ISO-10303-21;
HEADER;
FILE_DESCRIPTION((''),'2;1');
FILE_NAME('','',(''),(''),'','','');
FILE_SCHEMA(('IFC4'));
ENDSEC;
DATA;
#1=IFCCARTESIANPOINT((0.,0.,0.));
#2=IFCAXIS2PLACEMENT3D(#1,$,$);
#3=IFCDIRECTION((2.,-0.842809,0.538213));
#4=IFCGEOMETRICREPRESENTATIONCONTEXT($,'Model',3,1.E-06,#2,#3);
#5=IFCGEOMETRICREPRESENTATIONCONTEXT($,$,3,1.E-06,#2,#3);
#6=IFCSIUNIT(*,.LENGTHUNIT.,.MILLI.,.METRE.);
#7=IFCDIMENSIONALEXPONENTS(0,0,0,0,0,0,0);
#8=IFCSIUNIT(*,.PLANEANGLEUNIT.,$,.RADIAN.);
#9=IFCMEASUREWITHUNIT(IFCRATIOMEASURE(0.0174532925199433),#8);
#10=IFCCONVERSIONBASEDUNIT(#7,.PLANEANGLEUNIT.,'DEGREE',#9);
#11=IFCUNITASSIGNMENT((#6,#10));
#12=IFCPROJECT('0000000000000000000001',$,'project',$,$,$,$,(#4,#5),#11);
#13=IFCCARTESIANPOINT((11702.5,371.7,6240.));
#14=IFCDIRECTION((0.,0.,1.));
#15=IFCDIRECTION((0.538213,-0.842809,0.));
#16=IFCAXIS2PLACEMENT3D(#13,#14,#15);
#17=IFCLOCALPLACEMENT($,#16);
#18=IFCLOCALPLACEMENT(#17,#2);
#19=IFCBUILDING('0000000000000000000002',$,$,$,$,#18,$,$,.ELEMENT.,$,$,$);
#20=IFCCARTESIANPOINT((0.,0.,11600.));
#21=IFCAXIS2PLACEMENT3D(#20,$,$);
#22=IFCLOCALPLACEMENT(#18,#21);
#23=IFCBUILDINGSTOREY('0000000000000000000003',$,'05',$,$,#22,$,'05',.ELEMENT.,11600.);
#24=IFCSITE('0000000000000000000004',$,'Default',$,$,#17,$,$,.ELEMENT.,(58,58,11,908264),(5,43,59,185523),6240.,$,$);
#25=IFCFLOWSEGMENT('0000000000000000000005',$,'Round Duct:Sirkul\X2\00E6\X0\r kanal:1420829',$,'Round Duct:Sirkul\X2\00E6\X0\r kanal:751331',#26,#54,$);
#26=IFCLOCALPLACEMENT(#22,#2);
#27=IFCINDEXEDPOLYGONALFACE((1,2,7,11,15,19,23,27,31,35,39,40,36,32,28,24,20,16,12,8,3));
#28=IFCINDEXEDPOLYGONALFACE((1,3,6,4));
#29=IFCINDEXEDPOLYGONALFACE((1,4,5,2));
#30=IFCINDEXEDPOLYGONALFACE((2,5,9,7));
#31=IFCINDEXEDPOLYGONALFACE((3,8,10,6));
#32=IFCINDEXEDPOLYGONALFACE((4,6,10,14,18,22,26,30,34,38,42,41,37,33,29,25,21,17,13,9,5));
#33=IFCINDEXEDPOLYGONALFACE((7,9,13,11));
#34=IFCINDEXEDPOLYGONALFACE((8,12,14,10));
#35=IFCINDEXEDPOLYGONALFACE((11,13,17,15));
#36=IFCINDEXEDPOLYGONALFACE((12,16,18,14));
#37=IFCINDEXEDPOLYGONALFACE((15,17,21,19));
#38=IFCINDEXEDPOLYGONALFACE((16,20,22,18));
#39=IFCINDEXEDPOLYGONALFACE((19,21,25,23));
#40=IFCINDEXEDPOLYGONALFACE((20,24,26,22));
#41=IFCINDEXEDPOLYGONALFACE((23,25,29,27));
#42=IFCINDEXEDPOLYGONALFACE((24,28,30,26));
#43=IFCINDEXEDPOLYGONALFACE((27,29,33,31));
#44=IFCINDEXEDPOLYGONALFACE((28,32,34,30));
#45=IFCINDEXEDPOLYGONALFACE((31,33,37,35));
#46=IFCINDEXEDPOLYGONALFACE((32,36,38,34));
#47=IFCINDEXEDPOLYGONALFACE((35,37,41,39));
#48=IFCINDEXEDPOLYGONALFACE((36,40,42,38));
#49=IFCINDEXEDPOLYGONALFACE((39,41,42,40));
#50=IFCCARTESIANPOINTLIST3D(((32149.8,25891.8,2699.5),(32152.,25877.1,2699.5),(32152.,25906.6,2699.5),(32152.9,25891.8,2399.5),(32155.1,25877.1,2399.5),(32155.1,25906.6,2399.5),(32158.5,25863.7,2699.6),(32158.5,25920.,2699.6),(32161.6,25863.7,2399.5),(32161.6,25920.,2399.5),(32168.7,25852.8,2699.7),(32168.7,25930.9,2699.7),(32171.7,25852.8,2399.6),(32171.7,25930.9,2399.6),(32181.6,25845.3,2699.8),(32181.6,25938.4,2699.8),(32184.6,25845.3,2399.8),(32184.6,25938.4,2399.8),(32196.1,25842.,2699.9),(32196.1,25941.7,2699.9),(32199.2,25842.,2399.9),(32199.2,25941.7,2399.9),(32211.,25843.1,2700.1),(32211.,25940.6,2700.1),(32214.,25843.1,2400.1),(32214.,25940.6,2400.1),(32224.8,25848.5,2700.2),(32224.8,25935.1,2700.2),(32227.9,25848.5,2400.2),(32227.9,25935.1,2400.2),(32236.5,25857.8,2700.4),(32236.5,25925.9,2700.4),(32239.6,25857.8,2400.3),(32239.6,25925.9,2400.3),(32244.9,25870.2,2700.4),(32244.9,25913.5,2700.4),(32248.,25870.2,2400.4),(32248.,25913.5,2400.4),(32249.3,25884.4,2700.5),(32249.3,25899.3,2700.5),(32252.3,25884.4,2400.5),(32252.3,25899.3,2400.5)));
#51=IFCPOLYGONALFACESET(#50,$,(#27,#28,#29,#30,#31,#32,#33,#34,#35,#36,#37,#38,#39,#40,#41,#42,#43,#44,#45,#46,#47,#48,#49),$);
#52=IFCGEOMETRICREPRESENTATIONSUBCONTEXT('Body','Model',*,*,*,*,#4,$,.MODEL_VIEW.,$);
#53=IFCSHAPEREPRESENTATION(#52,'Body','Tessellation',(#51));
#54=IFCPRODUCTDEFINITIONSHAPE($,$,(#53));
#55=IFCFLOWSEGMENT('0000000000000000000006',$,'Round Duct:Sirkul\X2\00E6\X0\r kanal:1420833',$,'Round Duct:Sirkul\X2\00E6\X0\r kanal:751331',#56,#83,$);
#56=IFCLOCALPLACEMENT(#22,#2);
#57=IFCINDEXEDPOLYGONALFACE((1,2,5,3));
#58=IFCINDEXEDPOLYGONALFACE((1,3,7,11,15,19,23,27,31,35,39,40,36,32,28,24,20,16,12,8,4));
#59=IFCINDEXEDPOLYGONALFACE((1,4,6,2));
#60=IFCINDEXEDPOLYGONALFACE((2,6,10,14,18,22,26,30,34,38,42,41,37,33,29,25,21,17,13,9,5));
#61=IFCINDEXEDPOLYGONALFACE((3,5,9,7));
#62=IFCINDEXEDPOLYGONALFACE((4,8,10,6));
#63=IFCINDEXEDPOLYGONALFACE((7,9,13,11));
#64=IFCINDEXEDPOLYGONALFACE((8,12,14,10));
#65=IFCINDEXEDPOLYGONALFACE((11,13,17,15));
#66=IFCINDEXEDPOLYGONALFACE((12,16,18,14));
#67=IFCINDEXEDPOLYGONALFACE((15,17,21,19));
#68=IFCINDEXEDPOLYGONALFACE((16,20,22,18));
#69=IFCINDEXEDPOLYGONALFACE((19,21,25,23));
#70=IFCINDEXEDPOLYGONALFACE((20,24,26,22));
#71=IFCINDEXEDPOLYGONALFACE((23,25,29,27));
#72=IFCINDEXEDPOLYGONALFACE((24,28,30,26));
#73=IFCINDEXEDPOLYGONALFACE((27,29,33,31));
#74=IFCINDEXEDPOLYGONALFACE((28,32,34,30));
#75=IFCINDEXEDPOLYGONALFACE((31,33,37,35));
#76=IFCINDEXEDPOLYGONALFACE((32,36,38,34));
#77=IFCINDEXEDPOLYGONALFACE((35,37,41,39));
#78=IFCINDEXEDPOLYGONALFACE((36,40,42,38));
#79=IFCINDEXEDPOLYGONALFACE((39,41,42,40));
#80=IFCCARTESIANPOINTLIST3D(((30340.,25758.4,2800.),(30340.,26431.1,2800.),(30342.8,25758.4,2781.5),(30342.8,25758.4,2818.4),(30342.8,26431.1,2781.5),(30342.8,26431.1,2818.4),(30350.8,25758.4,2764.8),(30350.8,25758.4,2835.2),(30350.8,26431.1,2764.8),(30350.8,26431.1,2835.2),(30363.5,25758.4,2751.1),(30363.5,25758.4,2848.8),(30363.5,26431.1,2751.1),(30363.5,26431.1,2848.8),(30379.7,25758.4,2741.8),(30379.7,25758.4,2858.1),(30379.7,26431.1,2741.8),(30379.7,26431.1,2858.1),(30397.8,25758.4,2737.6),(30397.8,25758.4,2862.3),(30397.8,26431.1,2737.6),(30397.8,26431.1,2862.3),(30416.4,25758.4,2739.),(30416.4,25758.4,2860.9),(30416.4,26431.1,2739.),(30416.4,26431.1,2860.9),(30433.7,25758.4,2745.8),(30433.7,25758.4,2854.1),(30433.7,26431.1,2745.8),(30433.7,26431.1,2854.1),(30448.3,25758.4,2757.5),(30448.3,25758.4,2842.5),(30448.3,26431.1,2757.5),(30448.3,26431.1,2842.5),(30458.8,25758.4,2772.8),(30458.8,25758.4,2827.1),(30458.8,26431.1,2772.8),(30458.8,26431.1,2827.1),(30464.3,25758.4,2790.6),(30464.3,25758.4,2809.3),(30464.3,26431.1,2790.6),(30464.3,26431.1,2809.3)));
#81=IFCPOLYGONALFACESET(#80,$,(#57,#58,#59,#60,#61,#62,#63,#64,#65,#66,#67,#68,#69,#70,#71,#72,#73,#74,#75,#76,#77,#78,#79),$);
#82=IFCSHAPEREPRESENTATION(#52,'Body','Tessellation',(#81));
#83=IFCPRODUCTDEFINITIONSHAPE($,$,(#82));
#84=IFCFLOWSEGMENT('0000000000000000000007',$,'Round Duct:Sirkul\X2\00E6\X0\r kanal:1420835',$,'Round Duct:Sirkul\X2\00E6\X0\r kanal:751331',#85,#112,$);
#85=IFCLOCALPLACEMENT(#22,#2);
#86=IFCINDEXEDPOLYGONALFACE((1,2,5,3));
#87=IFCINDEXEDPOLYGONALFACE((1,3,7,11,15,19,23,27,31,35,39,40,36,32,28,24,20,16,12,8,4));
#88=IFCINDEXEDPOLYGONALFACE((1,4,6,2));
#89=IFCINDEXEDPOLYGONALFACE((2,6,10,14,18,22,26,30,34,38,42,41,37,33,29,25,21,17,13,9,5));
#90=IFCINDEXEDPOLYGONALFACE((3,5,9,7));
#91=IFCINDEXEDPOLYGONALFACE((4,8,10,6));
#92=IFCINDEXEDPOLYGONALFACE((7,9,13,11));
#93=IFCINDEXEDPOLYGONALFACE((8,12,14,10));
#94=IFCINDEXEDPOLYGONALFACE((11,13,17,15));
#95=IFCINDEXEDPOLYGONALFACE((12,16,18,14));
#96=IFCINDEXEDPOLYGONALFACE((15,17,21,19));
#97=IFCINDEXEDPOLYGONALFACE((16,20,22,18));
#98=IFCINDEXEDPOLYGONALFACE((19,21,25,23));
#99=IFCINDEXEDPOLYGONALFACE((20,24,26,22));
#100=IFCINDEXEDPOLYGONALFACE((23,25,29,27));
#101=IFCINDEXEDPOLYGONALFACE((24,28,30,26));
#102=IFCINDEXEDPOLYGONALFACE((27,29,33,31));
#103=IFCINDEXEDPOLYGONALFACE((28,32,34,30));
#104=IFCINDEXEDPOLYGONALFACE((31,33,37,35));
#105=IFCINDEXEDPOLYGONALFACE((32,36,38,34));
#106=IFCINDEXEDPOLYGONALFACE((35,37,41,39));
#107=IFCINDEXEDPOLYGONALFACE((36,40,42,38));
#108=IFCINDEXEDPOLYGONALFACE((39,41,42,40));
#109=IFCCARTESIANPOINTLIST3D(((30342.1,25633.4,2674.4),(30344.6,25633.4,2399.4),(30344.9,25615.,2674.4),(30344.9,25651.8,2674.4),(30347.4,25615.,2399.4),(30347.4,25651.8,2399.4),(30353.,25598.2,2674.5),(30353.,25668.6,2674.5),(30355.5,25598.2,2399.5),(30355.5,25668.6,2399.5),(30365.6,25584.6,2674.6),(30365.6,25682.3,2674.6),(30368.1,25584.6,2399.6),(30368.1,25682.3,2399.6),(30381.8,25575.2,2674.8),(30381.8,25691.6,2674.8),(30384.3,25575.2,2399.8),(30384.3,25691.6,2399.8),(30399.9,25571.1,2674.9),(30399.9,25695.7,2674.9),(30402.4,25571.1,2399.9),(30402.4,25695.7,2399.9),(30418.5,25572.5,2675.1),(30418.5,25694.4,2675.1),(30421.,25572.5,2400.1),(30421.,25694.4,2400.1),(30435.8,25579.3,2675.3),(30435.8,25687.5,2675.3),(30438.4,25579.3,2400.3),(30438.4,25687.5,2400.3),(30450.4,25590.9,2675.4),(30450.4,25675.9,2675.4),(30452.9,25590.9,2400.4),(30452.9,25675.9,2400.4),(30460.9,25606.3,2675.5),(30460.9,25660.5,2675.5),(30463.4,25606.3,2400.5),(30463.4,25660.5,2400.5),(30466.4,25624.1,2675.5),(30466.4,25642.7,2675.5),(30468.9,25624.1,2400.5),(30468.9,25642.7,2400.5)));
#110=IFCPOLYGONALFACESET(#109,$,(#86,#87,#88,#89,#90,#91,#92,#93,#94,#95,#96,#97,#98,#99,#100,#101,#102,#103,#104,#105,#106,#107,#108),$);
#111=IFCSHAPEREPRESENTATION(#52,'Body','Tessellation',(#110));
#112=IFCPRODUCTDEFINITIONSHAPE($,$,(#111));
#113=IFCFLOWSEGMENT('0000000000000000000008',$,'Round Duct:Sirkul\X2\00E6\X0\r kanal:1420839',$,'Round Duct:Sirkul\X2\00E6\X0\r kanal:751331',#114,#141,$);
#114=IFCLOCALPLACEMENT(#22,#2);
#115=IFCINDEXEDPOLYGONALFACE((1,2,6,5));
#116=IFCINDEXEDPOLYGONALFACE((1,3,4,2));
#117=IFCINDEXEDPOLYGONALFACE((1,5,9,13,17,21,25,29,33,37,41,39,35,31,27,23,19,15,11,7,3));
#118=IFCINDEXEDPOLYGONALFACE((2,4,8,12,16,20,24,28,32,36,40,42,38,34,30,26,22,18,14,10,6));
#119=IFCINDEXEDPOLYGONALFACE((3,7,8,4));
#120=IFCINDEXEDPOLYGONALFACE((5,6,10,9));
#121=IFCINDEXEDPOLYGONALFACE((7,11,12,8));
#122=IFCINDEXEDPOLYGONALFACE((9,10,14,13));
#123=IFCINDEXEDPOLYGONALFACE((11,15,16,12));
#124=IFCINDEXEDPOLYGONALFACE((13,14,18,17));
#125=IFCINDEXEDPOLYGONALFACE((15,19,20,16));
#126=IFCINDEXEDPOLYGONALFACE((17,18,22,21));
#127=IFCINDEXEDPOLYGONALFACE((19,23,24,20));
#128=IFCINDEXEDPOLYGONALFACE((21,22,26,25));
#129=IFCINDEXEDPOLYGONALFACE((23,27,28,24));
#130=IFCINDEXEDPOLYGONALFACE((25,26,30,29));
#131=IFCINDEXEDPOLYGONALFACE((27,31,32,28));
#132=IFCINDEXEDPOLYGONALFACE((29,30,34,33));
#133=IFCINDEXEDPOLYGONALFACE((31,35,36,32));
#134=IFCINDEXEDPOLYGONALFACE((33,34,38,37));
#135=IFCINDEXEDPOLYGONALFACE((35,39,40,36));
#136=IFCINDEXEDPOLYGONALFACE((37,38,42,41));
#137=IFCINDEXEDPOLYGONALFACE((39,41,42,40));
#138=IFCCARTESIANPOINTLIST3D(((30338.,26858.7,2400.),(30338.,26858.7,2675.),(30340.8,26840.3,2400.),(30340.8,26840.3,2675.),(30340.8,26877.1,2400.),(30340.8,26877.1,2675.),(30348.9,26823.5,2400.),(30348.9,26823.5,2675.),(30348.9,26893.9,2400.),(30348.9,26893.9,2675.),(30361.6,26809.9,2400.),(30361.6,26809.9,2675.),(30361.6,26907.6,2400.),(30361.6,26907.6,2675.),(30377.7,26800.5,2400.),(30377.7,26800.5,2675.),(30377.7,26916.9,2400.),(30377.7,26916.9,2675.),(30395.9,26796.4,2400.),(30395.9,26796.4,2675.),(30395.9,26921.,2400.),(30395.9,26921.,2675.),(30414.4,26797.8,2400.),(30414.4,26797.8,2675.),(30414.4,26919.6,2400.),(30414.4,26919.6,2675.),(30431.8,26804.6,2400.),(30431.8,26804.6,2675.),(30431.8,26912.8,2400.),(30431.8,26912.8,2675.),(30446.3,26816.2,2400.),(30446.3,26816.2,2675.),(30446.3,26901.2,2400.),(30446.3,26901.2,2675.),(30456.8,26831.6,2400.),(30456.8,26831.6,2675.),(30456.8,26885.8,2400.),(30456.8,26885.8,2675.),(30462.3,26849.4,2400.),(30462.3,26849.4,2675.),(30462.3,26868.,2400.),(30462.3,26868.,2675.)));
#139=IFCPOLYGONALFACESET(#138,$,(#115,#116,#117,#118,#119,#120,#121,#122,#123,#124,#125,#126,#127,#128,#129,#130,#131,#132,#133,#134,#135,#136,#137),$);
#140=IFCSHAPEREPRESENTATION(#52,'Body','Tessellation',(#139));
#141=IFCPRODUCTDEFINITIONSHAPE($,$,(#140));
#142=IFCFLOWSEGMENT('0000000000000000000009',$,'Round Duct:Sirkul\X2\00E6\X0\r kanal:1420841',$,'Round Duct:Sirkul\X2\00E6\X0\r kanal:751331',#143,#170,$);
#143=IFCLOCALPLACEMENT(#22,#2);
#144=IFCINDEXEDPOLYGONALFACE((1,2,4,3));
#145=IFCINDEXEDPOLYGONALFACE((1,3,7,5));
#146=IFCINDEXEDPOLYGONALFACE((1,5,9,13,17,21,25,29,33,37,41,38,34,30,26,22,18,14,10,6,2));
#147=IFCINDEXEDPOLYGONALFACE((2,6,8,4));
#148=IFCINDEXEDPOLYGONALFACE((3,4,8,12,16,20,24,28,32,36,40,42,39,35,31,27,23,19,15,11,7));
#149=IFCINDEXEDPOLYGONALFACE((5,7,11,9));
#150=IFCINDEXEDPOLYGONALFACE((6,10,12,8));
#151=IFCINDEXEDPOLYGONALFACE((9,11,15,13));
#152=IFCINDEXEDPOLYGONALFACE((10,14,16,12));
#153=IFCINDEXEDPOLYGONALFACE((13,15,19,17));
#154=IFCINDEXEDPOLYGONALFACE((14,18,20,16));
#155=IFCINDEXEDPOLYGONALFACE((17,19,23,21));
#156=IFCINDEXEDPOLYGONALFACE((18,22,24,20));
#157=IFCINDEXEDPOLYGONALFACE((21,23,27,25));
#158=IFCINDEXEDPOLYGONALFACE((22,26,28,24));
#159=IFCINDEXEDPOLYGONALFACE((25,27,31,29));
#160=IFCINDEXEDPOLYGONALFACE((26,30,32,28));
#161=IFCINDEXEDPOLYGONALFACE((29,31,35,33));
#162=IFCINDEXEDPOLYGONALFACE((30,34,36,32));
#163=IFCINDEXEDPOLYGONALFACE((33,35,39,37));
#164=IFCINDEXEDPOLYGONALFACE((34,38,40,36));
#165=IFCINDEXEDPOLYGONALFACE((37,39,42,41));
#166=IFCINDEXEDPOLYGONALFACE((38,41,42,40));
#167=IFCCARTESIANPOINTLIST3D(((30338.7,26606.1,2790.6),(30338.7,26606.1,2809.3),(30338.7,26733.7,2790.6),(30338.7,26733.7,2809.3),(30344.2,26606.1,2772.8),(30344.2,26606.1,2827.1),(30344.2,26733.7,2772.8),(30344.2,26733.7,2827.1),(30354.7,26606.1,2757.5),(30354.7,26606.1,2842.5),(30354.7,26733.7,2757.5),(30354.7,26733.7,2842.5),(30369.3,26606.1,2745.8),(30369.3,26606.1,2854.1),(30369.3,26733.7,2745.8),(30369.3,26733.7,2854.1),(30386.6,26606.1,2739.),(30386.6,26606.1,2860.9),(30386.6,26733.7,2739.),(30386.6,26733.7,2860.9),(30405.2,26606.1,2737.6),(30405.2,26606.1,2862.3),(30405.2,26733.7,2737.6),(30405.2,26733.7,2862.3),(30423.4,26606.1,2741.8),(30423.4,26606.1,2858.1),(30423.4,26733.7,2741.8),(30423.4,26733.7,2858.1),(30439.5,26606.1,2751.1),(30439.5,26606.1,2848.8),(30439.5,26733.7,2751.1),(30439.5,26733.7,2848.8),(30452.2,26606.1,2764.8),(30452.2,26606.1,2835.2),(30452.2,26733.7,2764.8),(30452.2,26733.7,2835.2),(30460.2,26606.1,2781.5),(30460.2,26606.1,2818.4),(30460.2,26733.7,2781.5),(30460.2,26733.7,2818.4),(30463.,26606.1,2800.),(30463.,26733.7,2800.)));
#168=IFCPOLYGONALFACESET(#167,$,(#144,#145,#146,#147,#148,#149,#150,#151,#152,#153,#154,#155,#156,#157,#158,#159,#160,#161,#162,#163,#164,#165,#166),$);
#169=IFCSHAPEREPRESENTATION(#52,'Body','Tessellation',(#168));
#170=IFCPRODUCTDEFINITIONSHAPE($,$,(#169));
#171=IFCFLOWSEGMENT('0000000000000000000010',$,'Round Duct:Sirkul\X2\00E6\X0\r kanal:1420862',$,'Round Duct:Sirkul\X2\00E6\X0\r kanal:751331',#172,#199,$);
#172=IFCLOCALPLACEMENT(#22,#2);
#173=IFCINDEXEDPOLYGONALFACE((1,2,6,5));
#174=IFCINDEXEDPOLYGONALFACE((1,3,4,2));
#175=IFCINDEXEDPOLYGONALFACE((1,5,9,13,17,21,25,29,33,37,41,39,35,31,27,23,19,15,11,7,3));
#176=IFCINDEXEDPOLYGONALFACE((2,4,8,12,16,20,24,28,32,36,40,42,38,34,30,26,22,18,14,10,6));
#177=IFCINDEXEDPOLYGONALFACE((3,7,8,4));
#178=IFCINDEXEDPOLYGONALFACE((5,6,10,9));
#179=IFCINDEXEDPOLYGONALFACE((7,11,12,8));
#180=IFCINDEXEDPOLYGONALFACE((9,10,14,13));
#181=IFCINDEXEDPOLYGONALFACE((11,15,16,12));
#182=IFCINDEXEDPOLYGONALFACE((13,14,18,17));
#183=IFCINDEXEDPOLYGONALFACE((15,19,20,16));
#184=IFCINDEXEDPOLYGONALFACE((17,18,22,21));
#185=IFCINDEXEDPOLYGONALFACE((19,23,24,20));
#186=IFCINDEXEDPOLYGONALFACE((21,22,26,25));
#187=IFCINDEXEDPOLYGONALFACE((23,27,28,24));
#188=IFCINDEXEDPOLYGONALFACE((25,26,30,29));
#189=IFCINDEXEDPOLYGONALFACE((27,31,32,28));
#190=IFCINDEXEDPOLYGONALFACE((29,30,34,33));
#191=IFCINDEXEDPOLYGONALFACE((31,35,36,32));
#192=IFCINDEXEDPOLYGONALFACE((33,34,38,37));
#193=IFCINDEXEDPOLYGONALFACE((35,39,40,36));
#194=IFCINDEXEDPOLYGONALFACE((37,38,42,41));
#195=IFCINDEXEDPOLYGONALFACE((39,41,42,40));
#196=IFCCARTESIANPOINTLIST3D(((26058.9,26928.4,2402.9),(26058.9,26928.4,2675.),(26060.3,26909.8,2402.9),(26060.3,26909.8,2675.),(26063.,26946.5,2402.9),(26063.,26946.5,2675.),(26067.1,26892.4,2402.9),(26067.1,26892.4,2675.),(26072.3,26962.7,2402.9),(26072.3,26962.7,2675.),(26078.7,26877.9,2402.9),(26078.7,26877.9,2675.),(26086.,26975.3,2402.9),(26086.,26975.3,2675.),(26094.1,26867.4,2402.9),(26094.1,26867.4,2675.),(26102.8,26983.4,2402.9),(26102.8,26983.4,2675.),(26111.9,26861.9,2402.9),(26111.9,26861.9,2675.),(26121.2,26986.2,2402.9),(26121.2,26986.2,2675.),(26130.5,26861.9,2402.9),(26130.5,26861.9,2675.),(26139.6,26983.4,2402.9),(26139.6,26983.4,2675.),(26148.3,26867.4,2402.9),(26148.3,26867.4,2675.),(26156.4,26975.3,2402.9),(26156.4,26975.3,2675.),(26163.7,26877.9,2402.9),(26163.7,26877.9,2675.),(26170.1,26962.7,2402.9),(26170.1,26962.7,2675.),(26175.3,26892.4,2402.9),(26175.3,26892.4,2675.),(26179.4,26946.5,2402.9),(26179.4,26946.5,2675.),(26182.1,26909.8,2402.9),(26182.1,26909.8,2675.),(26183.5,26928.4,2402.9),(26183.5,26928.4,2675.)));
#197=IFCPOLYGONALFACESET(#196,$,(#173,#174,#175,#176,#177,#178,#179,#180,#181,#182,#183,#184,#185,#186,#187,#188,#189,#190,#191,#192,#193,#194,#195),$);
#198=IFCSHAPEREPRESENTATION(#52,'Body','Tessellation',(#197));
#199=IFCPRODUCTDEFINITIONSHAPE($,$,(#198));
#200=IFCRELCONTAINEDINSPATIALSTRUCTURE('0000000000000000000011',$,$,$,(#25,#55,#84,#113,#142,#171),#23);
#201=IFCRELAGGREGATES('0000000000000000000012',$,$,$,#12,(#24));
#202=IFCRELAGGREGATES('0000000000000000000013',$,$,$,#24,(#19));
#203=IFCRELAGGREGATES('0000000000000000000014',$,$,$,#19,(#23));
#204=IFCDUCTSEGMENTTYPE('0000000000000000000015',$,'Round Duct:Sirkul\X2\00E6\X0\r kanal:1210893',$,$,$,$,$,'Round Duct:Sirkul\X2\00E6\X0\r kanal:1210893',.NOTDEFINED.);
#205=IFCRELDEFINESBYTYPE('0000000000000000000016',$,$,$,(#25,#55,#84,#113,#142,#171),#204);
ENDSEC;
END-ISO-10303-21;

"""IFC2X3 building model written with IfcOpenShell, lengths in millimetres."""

from ifc_helpers import new_model, entity, si_unit, converted_unit, direction, frame, frame_2d, origin, origin_2d_with_axis, place, context, subcontext, project, spatial, circle, extrude, type_object, element, save


model = new_model("IFC2X3")

# Units and contexts
model_context = context("Model", 3, precision=1e-06, world=origin(), true_north=direction((2.0, -0.842809, 0.538213)))
context_of_model = context(None, 3, precision=1e-06, world=origin(), true_north=direction((2.0, -0.842809, 0.538213)))
body_context = subcontext(model_context, "Body", "Model", "MODEL_VIEW")
ifc_project = project(units=[si_unit("LENGTHUNIT", "METRE", prefix="MILLI"), converted_unit("PLANEANGLEUNIT", "DEGREE", entity("IfcRatioMeasure", 0.0174532925199433), si_unit("PLANEANGLEUNIT", "RADIAN"), dimensions=[0, 0, 0, 0, 0, 0, 0])], contexts=[model_context, context_of_model])

# Site, building, storey
site_placement = place(None, frame((11702.5, 371.7, 6240.0), z_axis=(0.0, 0.0, 1.0), x_axis=(0.538213, -0.842809, 0.0)))
site = spatial("IfcSite", under=ifc_project, at=site_placement, Name="Default", CompositionType="ELEMENT", RefLatitude=(58, 58, 11, 908264), RefLongitude=(5, 43, 59, 185523), RefElevation=6240.0)
building_placement = place(site_placement, origin())
building = spatial("IfcBuilding", under=site, at=building_placement, CompositionType="ELEMENT")
storey_placement = place(building_placement, frame((0.0, 0.0, 11600.0)))
storey = spatial("IfcBuildingStorey", under=building, at=storey_placement, Name="05", LongName="05", CompositionType="ELEMENT", Elevation=11600.0)

# Flow segments
duct_segment_type = type_object("IfcDuctSegmentType", Name="Round Duct:Sirkulær kanal:1210893", ElementType="Round Duct:Sirkulær kanal:1210893", PredefinedType="NOTDEFINED")
flow_segment_1_placement = place(storey_placement, origin())
element("IfcFlowSegment", 1, at=flow_segment_1_placement, inside=storey, type_object=duct_segment_type, Name="Round Duct:Sirkulær kanal:1420829", ObjectType="Round Duct:Sirkulær kanal:751331", context=body_context, shape_type="SweptSolid", body=[
    extrude(circle(Radius=50.0, at=frame_2d((0.0, 0.0), x_axis=(1.0, 0.0))), frame((32202.9, 25891.8, 2400.0), z_axis=(-0.01027, 0.0, 0.999947), x_axis=(-0.999947, 0.0, -0.01027)), (0.0, 0.0, 1.0), 300.0),
])
flow_segment_2_placement = place(storey_placement, origin())
element("IfcFlowSegment", 2, at=flow_segment_2_placement, inside=storey, type_object=duct_segment_type, Name="Round Duct:Sirkulær kanal:1420833", ObjectType="Round Duct:Sirkulær kanal:751331", context=body_context, shape_type="SweptSolid", body=[
    extrude(circle(Radius=62.5, at=frame_2d((0.0, 0.0), x_axis=(1.0, 0.0))), frame((30402.5, 25758.4, 2800.0), z_axis=(0.0, 1.0, 0.0), x_axis=(-1.0, 0.0, 0.0)), (0.0, 0.0, 1.0), 672.7),
])
flow_segment_3_placement = place(storey_placement, origin())
element("IfcFlowSegment", 3, at=flow_segment_3_placement, inside=storey, type_object=duct_segment_type, Name="Round Duct:Sirkulær kanal:1420835", ObjectType="Round Duct:Sirkulær kanal:751331", context=body_context, shape_type="SweptSolid", body=[
    extrude(circle(Radius=62.5, at=origin_2d_with_axis()), frame((30407.1, 25633.4, 2400.0), z_axis=(-0.009167, 0.0, 0.999958), x_axis=(-0.999958, 0.0, -0.009167)), (0.0, 0.0, 1.0), 275.0),
])
flow_segment_4_placement = place(storey_placement, origin())
element("IfcFlowSegment", 4, at=flow_segment_4_placement, inside=storey, type_object=duct_segment_type, Name="Round Duct:Sirkulær kanal:1420839", ObjectType="Round Duct:Sirkulær kanal:751331", context=body_context, shape_type="SweptSolid", body=[
    extrude(circle(Radius=62.5, at=origin_2d_with_axis()), frame((30400.5, 26858.7, 2400.0), z_axis=(0.0, 0.0, 1.0), x_axis=(-1.0, 0.0, 0.0)), (0.0, 0.0, 1.0), 275.0),
])
flow_segment_5_placement = place(storey_placement, origin())
element("IfcFlowSegment", 5, at=flow_segment_5_placement, inside=storey, type_object=duct_segment_type, Name="Round Duct:Sirkulær kanal:1420841", ObjectType="Round Duct:Sirkulær kanal:751331", context=body_context, shape_type="SweptSolid", body=[
    extrude(circle(Radius=62.5, at=origin_2d_with_axis()), frame((30400.5, 26606.1, 2800.0), z_axis=(0.0, 1.0, 0.0), x_axis=(1.0, 0.0, 0.0)), (0.0, 0.0, 1.0), 127.6),
])
flow_segment_6_placement = place(storey_placement, origin())
element("IfcFlowSegment", 6, at=flow_segment_6_placement, inside=storey, type_object=duct_segment_type, Name="Round Duct:Sirkulær kanal:1420862", ObjectType="Round Duct:Sirkulær kanal:751331", context=body_context, shape_type="SweptSolid", body=[
    extrude(circle(Radius=62.5, at=frame_2d((0.0, 0.0), x_axis=(1.0, 0.0))), frame((26121.2, 26923.7, 2402.9), z_axis=(0.0, 0.0, 1.0), x_axis=(0.0, 1.0, 0.0)), (0.0, 0.0, 1.0), 272.0),
])

save(model, "model.ifc")
